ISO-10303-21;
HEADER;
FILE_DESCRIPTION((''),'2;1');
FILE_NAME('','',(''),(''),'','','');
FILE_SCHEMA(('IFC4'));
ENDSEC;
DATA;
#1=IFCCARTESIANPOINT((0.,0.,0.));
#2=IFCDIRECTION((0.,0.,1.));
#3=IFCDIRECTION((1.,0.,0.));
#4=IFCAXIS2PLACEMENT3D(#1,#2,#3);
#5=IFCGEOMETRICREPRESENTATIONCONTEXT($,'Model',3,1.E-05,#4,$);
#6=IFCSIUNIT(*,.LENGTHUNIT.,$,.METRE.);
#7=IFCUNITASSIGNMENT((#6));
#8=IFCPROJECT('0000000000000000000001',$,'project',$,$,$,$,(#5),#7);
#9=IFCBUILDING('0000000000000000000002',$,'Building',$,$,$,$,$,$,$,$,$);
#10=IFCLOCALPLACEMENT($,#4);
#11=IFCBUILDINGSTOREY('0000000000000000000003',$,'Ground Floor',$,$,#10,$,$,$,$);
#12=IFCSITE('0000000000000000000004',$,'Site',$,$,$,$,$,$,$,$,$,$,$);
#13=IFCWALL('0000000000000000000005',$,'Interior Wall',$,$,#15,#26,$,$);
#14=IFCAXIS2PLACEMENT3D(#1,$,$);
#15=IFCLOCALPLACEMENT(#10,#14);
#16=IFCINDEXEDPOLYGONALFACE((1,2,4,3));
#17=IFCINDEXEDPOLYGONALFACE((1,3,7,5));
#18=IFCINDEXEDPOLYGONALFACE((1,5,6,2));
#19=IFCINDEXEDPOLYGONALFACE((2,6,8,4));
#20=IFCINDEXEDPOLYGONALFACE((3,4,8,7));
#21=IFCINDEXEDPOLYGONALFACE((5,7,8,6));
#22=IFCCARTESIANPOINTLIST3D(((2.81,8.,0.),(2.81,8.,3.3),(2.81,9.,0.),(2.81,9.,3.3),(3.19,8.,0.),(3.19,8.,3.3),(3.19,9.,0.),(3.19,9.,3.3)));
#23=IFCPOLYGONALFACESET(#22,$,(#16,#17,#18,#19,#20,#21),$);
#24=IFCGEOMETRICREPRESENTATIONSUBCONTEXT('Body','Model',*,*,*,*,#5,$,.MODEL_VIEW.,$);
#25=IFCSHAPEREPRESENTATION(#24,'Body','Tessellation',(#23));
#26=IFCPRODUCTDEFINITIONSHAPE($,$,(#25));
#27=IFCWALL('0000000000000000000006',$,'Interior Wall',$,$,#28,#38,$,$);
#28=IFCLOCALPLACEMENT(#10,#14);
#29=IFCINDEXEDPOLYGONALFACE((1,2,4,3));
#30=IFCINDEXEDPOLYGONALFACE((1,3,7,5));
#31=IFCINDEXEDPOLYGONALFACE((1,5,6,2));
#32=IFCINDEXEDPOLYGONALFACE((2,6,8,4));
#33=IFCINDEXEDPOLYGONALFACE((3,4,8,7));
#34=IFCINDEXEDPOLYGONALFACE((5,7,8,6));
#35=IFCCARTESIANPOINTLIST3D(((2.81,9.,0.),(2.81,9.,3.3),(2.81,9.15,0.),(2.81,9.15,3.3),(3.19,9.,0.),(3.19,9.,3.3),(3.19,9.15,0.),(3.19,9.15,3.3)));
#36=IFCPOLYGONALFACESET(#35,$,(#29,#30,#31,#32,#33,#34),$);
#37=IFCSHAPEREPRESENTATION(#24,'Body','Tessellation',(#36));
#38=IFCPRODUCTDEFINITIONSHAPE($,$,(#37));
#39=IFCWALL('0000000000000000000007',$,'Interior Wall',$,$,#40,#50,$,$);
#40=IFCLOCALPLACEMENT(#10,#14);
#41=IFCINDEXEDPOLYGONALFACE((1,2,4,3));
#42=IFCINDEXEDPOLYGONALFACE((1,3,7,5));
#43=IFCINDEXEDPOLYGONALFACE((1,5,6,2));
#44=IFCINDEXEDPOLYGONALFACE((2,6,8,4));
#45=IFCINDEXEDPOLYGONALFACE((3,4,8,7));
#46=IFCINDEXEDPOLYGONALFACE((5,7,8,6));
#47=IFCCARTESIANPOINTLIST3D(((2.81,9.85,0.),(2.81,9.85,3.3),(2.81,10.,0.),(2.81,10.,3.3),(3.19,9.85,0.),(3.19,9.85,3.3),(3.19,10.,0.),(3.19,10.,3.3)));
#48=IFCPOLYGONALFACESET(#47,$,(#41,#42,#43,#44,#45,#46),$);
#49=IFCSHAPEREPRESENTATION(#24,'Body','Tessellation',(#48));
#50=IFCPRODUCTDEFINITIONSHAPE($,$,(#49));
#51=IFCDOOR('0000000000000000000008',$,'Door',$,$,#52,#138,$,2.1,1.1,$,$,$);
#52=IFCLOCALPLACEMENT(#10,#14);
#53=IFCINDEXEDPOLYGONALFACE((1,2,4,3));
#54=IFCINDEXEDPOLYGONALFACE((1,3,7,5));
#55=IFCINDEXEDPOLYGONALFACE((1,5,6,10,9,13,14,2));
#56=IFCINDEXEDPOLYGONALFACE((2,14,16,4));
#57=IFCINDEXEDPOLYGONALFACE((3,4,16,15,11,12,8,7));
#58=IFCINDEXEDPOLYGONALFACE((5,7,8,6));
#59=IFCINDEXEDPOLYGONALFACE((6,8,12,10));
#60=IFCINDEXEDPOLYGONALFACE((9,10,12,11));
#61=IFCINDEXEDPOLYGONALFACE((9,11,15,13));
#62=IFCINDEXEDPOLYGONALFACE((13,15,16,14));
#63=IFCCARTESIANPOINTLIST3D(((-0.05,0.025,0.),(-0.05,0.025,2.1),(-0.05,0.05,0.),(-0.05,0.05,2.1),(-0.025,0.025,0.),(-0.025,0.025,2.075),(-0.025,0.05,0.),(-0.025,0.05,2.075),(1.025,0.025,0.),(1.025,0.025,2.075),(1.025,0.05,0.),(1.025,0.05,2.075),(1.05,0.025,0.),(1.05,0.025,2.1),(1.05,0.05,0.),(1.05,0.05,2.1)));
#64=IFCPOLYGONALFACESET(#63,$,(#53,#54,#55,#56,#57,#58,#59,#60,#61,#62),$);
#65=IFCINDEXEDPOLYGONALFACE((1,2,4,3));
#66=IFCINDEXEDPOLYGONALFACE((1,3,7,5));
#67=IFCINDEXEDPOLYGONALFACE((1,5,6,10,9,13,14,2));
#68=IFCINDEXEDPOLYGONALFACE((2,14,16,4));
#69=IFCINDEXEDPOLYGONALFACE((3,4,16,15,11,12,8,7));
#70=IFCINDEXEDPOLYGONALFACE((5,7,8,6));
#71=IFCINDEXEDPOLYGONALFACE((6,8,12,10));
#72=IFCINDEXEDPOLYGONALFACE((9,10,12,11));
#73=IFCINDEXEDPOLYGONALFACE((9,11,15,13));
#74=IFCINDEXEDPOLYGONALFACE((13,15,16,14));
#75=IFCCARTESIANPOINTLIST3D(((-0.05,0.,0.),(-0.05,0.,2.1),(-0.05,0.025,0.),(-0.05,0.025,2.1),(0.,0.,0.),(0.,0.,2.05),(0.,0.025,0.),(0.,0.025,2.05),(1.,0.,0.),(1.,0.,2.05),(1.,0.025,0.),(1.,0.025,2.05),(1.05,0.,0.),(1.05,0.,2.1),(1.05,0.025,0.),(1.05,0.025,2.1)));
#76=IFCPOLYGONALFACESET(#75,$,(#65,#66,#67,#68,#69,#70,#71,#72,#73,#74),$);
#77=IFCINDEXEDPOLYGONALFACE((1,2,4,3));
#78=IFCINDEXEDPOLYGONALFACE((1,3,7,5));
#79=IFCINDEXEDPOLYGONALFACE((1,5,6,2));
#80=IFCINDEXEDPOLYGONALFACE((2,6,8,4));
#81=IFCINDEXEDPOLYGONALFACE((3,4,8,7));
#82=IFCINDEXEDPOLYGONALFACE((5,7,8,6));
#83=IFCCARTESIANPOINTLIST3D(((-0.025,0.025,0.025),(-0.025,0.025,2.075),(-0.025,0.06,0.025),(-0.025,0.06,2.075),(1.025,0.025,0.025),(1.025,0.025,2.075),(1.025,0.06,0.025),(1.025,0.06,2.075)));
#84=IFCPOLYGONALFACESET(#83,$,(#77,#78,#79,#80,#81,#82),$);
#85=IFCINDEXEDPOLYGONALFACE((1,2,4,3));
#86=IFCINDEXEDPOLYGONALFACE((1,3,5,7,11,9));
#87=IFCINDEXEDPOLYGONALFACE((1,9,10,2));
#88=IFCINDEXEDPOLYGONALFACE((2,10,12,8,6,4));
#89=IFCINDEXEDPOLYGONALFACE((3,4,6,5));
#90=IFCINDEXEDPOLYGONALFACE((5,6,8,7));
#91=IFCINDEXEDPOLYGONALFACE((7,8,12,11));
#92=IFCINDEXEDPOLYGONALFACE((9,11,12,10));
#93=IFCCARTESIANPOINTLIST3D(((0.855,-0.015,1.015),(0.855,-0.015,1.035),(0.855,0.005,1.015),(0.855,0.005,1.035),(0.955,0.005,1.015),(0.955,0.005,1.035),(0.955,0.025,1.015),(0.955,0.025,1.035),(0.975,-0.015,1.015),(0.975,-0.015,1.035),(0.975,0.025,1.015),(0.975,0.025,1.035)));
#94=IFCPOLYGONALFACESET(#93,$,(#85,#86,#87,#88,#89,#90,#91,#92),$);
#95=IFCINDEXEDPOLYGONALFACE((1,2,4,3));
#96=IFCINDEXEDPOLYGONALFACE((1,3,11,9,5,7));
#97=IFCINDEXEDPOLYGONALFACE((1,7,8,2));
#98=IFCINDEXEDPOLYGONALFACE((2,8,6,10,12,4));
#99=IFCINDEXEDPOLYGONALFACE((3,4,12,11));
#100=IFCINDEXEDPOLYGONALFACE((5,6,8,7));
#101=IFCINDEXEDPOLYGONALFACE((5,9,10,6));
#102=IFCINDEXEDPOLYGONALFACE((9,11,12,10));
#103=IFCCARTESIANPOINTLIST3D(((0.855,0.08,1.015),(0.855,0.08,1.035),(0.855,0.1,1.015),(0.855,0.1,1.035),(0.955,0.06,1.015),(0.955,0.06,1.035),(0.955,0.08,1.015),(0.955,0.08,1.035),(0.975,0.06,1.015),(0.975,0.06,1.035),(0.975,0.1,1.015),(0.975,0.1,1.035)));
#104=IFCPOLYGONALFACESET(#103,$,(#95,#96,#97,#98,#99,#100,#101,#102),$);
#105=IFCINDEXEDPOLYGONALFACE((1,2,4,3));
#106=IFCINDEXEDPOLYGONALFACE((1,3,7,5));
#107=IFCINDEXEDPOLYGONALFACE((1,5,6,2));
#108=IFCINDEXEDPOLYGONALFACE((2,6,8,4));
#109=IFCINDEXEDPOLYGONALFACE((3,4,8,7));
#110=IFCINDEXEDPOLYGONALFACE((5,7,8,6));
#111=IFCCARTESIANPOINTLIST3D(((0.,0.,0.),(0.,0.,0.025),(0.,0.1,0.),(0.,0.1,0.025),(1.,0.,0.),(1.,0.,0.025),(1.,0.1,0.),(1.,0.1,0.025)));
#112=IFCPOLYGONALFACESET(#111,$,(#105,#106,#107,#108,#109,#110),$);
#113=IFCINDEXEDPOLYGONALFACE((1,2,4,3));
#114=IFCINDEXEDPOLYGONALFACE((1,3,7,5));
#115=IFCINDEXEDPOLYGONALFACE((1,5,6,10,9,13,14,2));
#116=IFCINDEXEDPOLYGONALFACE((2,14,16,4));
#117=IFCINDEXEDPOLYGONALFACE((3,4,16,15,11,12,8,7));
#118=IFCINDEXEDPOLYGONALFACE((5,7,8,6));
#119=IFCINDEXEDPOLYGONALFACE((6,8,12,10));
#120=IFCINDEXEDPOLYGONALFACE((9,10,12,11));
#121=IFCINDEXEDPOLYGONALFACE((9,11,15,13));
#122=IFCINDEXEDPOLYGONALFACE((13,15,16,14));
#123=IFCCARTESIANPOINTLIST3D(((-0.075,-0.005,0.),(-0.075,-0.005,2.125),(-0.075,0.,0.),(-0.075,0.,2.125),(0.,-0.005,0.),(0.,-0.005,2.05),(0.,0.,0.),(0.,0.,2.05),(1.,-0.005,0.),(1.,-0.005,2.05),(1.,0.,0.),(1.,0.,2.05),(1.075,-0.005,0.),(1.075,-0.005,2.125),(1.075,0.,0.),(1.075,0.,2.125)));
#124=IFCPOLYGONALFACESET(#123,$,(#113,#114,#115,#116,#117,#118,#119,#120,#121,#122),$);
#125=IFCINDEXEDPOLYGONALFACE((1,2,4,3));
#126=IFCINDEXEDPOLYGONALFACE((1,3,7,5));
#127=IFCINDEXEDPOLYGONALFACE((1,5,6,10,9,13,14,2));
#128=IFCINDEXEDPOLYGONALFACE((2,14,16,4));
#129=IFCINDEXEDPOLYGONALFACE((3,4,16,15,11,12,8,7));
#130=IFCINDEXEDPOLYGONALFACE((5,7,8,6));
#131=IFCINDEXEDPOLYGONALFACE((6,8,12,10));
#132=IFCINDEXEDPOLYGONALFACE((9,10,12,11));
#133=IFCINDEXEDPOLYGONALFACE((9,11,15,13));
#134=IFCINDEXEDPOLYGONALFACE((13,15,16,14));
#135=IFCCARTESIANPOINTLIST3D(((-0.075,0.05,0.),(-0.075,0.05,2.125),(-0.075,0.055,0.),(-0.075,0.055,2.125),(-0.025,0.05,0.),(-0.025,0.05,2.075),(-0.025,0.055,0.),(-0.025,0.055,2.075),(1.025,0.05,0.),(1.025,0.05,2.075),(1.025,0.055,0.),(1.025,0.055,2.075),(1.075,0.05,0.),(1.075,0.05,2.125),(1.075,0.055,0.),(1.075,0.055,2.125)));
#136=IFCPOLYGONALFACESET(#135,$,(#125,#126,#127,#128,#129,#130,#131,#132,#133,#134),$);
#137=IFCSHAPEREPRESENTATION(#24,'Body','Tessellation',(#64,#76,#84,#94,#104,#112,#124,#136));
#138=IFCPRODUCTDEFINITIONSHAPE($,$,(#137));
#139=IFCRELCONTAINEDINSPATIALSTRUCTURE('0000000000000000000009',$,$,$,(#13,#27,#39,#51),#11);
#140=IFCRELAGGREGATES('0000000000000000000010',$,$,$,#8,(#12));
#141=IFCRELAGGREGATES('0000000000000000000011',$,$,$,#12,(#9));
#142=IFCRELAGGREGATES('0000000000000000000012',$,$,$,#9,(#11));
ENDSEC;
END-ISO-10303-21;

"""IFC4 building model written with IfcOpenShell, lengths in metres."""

from ifc_helpers import new_model, si_unit, frame, origin_with_axes, place, context, subcontext, project, spatial, line, indexed_curve, outline, extrude, element, save


model = new_model("IFC4")

# Units and contexts
model_context = context("Model", 3, precision=1e-05, world=origin_with_axes())
body_context = subcontext(model_context, "Body", "Model", "MODEL_VIEW")
ifc_project = project(units=[si_unit("LENGTHUNIT", "METRE")], contexts=[model_context])

# Site, building, storey
site = spatial("IfcSite", under=ifc_project, Name="Site")
building = spatial("IfcBuilding", under=site, Name="Building")
storey_placement = place(None, origin_with_axes())
storey = spatial("IfcBuildingStorey", under=building, at=storey_placement, Name="Ground Floor")

# Walls
wall_1_placement = place(storey_placement, frame((3.0, 9.0, 0.0), z_axis=(0.0, 0.0, 1.0), x_axis=(0.0, -1.0, 0.0)))
element("IfcWall", 1, at=wall_1_placement, inside=storey, Name="Interior Wall", context=body_context, shape_type="SweptSolid", body=[
    extrude(outline(indexed_curve([(0.0, 0.0), (0.0, 0.38), (1.0, 0.38), (1.0, 0.0), (0.0, 0.0)], self_intersect=False)), frame((0.0, -0.19, 0.0), z_axis=(0.0, 0.0, 1.0), x_axis=(1.0, 0.0, 0.0)), (0.0, 0.0, 1.0), 3.3),
])
for number, where, z_axis, x_axis, name in (
    (2, (3.0, 9.0, 0.0), (0.0, 0.0, 1.0), (0.0, 1.0, 0.0), "Interior Wall"),
    (3, (3.0, 9.85, 0.0), (0.0, 0.0, 1.0), (0.0, 1.0, 0.0), "Interior Wall"),
):
    element("IfcWall", number, at=place(storey_placement, frame(where, z_axis=z_axis, x_axis=x_axis)), inside=storey, Name=name, context=body_context, shape_type="SweptSolid", body=[
        extrude(outline(indexed_curve([(0.0, 0.0), (0.0, 0.38), (0.15, 0.38), (0.15, 0.0), (0.0, 0.0)], self_intersect=False)), frame((0.0, -0.19, 0.0), z_axis=(0.0, 0.0, 1.0), x_axis=(1.0, 0.0, 0.0)), (0.0, 0.0, 1.0), 3.3),
    ])

# Door
door_1_placement = place(storey_placement, frame((-0.05, 0.0, 0.0), z_axis=(0.0, 0.0, 1.0), x_axis=(1.0, 0.0, 0.0)))
element("IfcDoor", 4, at=door_1_placement, inside=storey, Name="Door", OverallHeight=2.1, OverallWidth=1.1, context=body_context, shape_type="SweptSolid", body=[
    extrude(outline(indexed_curve([(0.0, 0.0), (0.0, 2.1), (1.1, 2.1), (1.1, 0.0), (1.075, 0.0), (1.075, 2.075), (0.025, 2.075), (0.025, 0.0)], segments=[line(1, 2, 3, 4, 5, 6, 7, 8, 1)])), frame((0.0, 0.025, 0.0), z_axis=(0.0, -1.0, 0.0), x_axis=(1.0, 0.0, 0.0)), (0.0, 0.0, -1.0), 0.025),
    extrude(outline(indexed_curve([(0.0, 0.0), (0.0, 2.1), (1.1, 2.1), (1.1, 0.0), (1.05, 0.0), (1.05, 2.05), (0.05, 2.05), (0.05, 0.0)], segments=[line(1, 2, 3, 4, 5, 6, 7, 8, 1)])), frame((0.0, 0.0, 0.0), z_axis=(0.0, -1.0, 0.0), x_axis=(1.0, 0.0, 0.0)), (0.0, 0.0, -1.0), 0.025),
    extrude(outline(indexed_curve([(0.0, 0.0), (1.05, 0.0), (1.05, 0.035), (0.0, 0.035)], segments=[line(1, 2, 3, 4, 1)])), frame((0.025, 0.025, 0.025), z_axis=(0.0, 0.0, 1.0), x_axis=(1.0, 0.0, 0.0)), (0.0, 0.0, 1.0), 2.05),
    extrude(outline(indexed_curve([(0.0, 0.0), (0.0, -0.04), (-0.12, -0.04), (-0.12, -0.02), (-0.02, -0.02), (-0.02, 0.0)], segments=[line(1, 2, 3, 4, 5, 6, 1)])), frame((1.025, 0.025, 1.015), z_axis=(0.0, 0.0, 1.0), x_axis=(1.0, 0.0, 0.0)), (0.0, 0.0, 1.0), 0.02),
    extrude(outline(indexed_curve([(0.0, 0.0), (0.0, 0.04), (-0.12, 0.04), (-0.12, 0.02), (-0.02, 0.02), (-0.02, 0.0)], segments=[line(1, 2, 3, 4, 5, 6, 1)])), frame((1.025, 0.06, 1.015), z_axis=(0.0, 0.0, 1.0), x_axis=(1.0, 0.0, 0.0)), (0.0, 0.0, 1.0), 0.02),
    extrude(outline(indexed_curve([(0.0, 0.0), (1.0, 0.0), (1.0, 0.1), (0.0, 0.1)], segments=[line(1, 2, 3, 4, 1)])), frame((0.05, 0.0, 0.0), z_axis=(0.0, 0.0, 1.0), x_axis=(1.0, 0.0, 0.0)), (0.0, 0.0, 1.0), 0.025),
    extrude(outline(indexed_curve([(0.0, 0.0), (0.0, 2.125), (1.15, 2.125), (1.15, 0.0), (1.075, 0.0), (1.075, 2.05), (0.075, 2.05), (0.075, 0.0)], segments=[line(1, 2, 3, 4, 5, 6, 7, 8, 1)])), frame((-0.025, -0.005, 0.0), z_axis=(0.0, -1.0, 0.0), x_axis=(1.0, 0.0, 0.0)), (0.0, 0.0, -1.0), 0.005),
    extrude(outline(indexed_curve([(0.0, 0.0), (0.0, 2.125), (1.15, 2.125), (1.15, 0.0), (1.1, 0.0), (1.1, 2.075), (0.05, 2.075), (0.05, 0.0)], segments=[line(1, 2, 3, 4, 5, 6, 7, 8, 1)])), frame((-0.025, 0.05, 0.0), z_axis=(0.0, -1.0, 0.0), x_axis=(1.0, 0.0, 0.0)), (0.0, 0.0, -1.0), 0.005),
])

save(model, "model.ifc")
